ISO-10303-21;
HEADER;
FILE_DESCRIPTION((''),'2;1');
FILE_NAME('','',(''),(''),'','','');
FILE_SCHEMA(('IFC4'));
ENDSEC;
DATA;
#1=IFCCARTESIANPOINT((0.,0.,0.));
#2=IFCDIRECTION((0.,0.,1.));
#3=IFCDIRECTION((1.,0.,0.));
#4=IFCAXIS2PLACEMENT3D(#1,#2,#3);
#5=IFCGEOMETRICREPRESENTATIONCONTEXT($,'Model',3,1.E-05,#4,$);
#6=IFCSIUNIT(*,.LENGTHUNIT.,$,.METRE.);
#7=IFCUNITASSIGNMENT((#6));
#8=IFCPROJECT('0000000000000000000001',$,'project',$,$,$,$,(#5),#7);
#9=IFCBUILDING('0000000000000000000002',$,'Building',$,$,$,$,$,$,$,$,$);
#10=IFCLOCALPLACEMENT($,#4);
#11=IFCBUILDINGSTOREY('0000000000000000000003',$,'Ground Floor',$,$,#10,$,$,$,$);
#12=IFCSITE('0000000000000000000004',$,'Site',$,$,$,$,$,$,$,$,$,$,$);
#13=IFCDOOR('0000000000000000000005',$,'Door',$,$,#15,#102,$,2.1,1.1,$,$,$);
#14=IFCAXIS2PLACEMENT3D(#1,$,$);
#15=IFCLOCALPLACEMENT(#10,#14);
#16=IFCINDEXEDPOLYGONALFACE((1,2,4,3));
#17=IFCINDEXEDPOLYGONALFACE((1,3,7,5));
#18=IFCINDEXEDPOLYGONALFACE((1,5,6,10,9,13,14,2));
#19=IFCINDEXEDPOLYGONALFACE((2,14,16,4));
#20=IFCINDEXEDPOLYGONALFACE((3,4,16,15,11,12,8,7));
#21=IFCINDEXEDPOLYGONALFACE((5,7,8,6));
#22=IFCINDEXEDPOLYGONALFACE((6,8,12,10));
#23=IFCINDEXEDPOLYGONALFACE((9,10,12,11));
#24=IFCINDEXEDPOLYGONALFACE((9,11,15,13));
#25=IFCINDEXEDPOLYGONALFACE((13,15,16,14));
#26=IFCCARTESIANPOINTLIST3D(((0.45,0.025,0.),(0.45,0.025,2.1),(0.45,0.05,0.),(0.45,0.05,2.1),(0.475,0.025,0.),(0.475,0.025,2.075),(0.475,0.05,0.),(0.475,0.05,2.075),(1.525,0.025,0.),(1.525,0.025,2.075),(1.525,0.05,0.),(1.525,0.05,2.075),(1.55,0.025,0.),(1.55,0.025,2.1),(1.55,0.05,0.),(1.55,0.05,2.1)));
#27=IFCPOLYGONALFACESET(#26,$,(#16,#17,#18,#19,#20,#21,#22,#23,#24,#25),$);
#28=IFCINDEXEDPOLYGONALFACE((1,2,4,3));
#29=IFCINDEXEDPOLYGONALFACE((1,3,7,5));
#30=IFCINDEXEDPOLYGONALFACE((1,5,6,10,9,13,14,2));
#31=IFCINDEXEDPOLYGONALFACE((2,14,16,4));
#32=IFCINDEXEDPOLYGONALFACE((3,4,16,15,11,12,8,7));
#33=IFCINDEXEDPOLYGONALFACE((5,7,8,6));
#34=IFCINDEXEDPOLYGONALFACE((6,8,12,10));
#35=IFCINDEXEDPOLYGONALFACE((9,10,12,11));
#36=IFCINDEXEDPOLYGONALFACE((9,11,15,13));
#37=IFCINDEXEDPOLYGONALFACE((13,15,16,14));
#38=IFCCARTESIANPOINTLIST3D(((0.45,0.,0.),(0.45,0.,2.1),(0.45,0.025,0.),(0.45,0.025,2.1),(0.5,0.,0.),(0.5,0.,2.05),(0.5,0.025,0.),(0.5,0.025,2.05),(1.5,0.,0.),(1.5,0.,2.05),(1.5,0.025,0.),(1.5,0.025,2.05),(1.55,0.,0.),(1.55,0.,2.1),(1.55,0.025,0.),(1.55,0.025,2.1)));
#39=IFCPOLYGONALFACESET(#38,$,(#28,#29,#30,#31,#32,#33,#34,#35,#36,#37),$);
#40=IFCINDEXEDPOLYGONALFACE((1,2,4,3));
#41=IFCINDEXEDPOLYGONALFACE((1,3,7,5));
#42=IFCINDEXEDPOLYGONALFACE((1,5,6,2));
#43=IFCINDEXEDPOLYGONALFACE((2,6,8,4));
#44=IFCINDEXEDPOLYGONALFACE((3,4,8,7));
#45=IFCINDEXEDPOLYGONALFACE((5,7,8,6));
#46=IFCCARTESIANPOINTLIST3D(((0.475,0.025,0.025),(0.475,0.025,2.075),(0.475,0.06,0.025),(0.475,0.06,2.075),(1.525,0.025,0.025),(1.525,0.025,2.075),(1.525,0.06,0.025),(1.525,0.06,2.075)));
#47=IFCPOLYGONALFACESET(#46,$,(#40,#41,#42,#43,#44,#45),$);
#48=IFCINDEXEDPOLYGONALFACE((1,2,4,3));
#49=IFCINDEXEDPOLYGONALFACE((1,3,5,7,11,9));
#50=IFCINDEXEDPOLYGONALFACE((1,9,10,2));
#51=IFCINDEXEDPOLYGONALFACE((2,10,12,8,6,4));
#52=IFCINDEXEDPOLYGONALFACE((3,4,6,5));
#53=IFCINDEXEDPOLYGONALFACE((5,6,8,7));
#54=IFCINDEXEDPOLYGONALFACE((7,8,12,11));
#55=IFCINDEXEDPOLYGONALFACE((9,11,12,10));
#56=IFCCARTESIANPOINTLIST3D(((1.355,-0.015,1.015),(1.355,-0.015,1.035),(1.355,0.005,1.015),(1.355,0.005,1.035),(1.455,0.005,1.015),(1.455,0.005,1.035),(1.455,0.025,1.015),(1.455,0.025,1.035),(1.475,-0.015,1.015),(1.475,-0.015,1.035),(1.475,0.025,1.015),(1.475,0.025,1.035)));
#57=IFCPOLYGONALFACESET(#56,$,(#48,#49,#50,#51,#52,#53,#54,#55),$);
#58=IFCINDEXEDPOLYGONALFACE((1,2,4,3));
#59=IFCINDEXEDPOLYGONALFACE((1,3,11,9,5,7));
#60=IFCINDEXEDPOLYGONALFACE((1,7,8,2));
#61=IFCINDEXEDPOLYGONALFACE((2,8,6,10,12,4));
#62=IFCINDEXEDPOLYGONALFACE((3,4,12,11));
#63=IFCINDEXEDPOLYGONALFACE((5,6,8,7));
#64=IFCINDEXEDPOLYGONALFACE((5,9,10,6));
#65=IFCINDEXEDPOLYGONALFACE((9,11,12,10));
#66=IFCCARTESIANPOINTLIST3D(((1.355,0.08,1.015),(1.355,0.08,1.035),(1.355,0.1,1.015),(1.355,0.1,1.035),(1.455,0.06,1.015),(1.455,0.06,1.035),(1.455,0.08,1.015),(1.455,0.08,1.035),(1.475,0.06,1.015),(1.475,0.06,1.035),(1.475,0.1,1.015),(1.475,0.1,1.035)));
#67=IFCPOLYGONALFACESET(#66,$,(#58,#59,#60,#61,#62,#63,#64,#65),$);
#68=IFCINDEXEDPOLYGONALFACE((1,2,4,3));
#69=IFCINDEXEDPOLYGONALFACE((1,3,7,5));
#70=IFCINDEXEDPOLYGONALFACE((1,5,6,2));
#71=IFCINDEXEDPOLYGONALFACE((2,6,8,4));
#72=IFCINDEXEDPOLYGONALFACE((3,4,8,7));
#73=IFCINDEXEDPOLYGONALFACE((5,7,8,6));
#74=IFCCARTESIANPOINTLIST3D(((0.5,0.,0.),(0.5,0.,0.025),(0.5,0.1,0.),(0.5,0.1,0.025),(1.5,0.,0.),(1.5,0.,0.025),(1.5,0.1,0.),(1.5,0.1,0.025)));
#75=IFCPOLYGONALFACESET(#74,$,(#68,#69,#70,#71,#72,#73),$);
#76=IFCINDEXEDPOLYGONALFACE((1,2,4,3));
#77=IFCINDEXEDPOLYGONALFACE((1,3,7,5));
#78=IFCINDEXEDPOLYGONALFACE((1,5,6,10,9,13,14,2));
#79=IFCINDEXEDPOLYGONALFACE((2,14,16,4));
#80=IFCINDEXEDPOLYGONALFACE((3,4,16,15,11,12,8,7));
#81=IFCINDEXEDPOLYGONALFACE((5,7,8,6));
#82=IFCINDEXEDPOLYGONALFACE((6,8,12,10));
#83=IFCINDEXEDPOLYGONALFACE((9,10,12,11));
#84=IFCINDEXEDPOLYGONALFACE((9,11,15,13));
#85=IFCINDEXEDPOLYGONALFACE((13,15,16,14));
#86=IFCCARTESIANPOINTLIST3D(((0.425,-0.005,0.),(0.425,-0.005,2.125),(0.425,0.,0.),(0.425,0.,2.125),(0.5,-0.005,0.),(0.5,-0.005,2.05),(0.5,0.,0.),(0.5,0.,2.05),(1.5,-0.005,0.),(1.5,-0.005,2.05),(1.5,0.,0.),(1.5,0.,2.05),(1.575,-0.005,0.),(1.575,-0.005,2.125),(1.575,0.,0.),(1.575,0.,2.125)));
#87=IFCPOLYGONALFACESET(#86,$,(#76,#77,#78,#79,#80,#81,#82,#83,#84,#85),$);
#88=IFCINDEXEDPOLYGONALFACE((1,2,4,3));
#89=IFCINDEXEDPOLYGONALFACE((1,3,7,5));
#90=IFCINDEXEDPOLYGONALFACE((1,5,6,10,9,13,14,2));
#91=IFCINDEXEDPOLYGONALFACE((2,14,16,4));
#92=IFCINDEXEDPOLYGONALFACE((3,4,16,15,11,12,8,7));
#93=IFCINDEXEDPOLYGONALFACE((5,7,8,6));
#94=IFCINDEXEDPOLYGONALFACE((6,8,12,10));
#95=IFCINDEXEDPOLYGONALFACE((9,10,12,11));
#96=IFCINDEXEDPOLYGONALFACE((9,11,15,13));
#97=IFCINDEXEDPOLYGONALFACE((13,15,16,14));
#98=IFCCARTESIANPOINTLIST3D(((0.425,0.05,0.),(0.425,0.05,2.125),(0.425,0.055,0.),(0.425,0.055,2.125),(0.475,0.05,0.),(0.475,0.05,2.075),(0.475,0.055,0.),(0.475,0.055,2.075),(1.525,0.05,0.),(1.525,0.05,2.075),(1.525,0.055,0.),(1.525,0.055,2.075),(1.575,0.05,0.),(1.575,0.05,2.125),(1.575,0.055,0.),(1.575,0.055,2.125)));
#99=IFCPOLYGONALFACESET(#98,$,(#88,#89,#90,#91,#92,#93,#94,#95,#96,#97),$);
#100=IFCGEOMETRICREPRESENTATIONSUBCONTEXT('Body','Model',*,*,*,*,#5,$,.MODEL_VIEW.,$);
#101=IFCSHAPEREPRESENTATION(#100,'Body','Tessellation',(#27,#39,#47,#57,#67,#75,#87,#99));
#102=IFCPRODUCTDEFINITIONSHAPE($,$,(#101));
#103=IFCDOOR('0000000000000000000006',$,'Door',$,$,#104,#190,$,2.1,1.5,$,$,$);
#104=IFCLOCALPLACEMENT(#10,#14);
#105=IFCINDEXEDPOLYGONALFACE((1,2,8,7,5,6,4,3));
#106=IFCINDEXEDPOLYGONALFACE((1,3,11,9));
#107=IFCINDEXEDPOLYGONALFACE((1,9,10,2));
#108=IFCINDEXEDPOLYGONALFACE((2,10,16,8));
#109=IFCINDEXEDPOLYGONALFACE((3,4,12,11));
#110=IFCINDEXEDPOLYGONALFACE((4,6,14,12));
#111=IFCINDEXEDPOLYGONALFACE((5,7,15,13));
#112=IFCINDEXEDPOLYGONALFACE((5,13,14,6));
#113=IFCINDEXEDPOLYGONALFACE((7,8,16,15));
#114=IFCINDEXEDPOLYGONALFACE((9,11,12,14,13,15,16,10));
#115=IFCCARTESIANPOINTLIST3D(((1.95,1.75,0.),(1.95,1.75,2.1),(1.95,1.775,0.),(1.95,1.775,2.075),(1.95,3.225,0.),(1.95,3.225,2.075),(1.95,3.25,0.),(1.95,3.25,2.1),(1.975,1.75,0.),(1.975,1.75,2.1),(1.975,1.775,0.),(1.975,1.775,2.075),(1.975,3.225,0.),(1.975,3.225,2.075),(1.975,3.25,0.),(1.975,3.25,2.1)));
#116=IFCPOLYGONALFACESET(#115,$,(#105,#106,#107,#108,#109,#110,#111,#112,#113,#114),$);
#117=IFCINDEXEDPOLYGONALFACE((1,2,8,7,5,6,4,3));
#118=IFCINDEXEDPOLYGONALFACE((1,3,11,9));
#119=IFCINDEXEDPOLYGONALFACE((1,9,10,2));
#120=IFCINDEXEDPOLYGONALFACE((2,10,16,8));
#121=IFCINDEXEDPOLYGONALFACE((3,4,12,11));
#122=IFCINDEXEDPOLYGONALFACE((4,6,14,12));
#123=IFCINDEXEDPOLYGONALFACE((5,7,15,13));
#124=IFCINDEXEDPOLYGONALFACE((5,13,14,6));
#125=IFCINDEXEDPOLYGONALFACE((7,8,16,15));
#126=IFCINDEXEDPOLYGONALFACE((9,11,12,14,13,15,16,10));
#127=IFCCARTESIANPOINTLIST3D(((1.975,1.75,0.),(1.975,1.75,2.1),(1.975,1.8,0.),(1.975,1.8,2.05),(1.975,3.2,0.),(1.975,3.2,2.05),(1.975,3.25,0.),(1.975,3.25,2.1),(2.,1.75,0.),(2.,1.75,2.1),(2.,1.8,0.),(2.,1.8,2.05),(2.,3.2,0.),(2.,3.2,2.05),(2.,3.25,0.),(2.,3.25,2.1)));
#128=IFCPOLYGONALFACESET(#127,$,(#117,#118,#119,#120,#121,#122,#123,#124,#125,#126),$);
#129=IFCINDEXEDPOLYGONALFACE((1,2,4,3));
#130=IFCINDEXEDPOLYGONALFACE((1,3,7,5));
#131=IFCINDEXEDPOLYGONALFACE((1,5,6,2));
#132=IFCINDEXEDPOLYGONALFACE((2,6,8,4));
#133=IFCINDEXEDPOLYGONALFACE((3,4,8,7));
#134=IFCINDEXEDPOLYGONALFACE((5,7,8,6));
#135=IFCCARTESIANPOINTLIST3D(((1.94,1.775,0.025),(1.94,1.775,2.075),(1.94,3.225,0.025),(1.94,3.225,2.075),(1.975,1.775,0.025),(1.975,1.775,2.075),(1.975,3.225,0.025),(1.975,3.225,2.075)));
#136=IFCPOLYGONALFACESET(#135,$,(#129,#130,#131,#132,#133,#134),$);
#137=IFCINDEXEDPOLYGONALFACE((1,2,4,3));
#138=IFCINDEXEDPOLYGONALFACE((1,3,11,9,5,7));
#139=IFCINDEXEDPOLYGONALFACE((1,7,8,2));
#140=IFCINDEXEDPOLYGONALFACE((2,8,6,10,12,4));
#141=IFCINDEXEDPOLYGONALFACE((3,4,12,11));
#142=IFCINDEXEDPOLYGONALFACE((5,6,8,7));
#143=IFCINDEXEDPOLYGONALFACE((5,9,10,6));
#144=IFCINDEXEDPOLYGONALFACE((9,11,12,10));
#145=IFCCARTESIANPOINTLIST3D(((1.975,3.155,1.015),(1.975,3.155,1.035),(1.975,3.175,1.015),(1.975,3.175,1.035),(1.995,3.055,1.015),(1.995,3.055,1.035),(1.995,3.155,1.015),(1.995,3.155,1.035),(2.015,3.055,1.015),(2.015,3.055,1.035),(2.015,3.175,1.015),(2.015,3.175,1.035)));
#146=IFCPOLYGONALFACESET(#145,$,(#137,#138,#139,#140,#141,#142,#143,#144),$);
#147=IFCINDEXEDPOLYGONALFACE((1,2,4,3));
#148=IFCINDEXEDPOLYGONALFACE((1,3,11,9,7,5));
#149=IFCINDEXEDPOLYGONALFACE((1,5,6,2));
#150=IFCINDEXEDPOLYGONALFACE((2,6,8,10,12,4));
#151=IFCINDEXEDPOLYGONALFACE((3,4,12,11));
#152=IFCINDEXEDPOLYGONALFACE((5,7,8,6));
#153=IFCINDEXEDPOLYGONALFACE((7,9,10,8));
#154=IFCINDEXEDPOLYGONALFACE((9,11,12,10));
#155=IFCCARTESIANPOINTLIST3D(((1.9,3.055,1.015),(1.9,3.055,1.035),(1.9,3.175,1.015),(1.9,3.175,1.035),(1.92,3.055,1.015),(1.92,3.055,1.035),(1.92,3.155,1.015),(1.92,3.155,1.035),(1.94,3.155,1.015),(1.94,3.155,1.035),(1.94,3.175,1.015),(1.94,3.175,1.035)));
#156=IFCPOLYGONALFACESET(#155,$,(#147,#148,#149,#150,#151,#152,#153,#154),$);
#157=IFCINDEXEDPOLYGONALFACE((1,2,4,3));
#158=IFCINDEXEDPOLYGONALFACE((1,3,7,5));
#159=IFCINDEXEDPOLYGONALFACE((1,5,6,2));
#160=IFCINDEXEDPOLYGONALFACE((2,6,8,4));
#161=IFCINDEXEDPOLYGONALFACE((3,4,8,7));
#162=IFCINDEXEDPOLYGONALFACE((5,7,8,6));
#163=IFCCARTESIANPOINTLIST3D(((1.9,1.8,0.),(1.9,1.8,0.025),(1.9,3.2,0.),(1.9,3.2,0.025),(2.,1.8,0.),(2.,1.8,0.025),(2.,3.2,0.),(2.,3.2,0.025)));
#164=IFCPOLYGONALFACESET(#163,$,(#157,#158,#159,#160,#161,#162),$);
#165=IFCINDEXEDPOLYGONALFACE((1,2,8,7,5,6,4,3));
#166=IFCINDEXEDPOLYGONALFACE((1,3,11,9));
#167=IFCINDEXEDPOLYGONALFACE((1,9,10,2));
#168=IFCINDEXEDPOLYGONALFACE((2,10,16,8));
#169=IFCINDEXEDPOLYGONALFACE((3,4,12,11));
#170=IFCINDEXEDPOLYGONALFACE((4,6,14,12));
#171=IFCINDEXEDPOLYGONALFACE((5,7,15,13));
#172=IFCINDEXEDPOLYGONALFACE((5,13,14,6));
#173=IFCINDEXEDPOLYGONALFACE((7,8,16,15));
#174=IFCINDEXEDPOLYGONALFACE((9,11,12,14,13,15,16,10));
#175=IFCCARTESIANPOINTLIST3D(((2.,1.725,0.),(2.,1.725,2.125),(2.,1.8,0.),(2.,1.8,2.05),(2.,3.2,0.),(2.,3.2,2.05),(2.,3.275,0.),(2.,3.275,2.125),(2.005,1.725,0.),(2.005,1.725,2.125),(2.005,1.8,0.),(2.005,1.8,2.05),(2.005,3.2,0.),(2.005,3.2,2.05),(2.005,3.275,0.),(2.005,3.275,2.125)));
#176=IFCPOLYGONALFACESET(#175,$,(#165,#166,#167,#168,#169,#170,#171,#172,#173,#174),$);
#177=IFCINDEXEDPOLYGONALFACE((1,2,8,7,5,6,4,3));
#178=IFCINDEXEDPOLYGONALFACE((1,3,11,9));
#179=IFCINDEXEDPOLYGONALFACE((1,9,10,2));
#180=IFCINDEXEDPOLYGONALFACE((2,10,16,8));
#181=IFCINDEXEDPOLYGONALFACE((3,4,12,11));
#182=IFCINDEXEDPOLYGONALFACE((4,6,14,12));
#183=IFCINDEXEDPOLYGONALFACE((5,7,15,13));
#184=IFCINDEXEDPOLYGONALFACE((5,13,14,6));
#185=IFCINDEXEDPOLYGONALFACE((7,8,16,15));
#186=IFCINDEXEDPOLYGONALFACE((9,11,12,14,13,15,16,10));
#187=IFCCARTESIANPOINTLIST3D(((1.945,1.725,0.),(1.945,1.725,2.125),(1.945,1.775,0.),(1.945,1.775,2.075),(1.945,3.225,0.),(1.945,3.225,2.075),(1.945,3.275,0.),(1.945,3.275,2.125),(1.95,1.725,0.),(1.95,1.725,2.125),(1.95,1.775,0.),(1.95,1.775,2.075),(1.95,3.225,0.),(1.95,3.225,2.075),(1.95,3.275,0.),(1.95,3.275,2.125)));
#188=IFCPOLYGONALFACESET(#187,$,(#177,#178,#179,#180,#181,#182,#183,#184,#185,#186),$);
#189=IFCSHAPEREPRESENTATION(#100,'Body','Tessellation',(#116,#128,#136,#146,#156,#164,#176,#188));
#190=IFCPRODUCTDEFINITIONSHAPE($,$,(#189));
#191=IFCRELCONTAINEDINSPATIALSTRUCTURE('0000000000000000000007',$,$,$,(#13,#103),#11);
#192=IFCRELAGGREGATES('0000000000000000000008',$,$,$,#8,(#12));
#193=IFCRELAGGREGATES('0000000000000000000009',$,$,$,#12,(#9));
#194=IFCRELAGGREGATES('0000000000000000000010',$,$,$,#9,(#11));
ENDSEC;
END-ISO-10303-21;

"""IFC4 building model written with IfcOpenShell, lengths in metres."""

from ifc_helpers import new_model, si_unit, frame, origin_with_axes, place, context, subcontext, project, spatial, line, indexed_curve, outline, extrude, element, save


model = new_model("IFC4")

# Units and contexts
model_context = context("Model", 3, precision=1e-05, world=origin_with_axes())
body_context = subcontext(model_context, "Body", "Model", "MODEL_VIEW")
ifc_project = project(units=[si_unit("LENGTHUNIT", "METRE")], contexts=[model_context])

# Site, building, storey
site = spatial("IfcSite", under=ifc_project, Name="Site")
building = spatial("IfcBuilding", under=site, Name="Building")
storey_placement = place(None, origin_with_axes())
storey = spatial("IfcBuildingStorey", under=building, at=storey_placement, Name="Ground Floor")

# Doors
door_1_placement = place(storey_placement, frame((0.45, 0.0, 0.0), z_axis=(0.0, 0.0, 1.0), x_axis=(1.0, 0.0, 0.0)))
element("IfcDoor", 1, at=door_1_placement, inside=storey, Name="Door", OverallHeight=2.1, OverallWidth=1.1, context=body_context, shape_type="SweptSolid", body=[
    extrude(outline(indexed_curve([(0.0, 0.0), (0.0, 2.1), (1.1, 2.1), (1.1, 0.0), (1.075, 0.0), (1.075, 2.075), (0.025, 2.075), (0.025, 0.0)], segments=[line(1, 2, 3, 4, 5, 6, 7, 8, 1)])), frame((0.0, 0.025, 0.0), z_axis=(0.0, -1.0, 0.0), x_axis=(1.0, 0.0, 0.0)), (0.0, 0.0, -1.0), 0.025),
    extrude(outline(indexed_curve([(0.0, 0.0), (0.0, 2.1), (1.1, 2.1), (1.1, 0.0), (1.05, 0.0), (1.05, 2.05), (0.05, 2.05), (0.05, 0.0)], segments=[line(1, 2, 3, 4, 5, 6, 7, 8, 1)])), frame((0.0, 0.0, 0.0), z_axis=(0.0, -1.0, 0.0), x_axis=(1.0, 0.0, 0.0)), (0.0, 0.0, -1.0), 0.025),
    extrude(outline(indexed_curve([(0.0, 0.0), (1.05, 0.0), (1.05, 0.035), (0.0, 0.035)], segments=[line(1, 2, 3, 4, 1)])), frame((0.025, 0.025, 0.025), z_axis=(0.0, 0.0, 1.0), x_axis=(1.0, 0.0, 0.0)), (0.0, 0.0, 1.0), 2.05),
    extrude(outline(indexed_curve([(0.0, 0.0), (0.0, -0.04), (-0.12, -0.04), (-0.12, -0.02), (-0.02, -0.02), (-0.02, 0.0)], segments=[line(1, 2, 3, 4, 5, 6, 1)])), frame((1.025, 0.025, 1.015), z_axis=(0.0, 0.0, 1.0), x_axis=(1.0, 0.0, 0.0)), (0.0, 0.0, 1.0), 0.02),
    extrude(outline(indexed_curve([(0.0, 0.0), (0.0, 0.04), (-0.12, 0.04), (-0.12, 0.02), (-0.02, 0.02), (-0.02, 0.0)], segments=[line(1, 2, 3, 4, 5, 6, 1)])), frame((1.025, 0.06, 1.015), z_axis=(0.0, 0.0, 1.0), x_axis=(1.0, 0.0, 0.0)), (0.0, 0.0, 1.0), 0.02),
    extrude(outline(indexed_curve([(0.0, 0.0), (1.0, 0.0), (1.0, 0.1), (0.0, 0.1)], segments=[line(1, 2, 3, 4, 1)])), frame((0.05, 0.0, 0.0), z_axis=(0.0, 0.0, 1.0), x_axis=(1.0, 0.0, 0.0)), (0.0, 0.0, 1.0), 0.025),
    extrude(outline(indexed_curve([(0.0, 0.0), (0.0, 2.125), (1.15, 2.125), (1.15, 0.0), (1.075, 0.0), (1.075, 2.05), (0.075, 2.05), (0.075, 0.0)], segments=[line(1, 2, 3, 4, 5, 6, 7, 8, 1)])), frame((-0.025, -0.005, 0.0), z_axis=(0.0, -1.0, 0.0), x_axis=(1.0, 0.0, 0.0)), (0.0, 0.0, -1.0), 0.005),
    extrude(outline(indexed_curve([(0.0, 0.0), (0.0, 2.125), (1.15, 2.125), (1.15, 0.0), (1.1, 0.0), (1.1, 2.075), (0.05, 2.075), (0.05, 0.0)], segments=[line(1, 2, 3, 4, 5, 6, 7, 8, 1)])), frame((-0.025, 0.05, 0.0), z_axis=(0.0, -1.0, 0.0), x_axis=(1.0, 0.0, 0.0)), (0.0, 0.0, -1.0), 0.005),
])
door_2_placement = place(storey_placement, frame((2.0, 1.75, 0.0), z_axis=(0.0, 0.0, 1.0), x_axis=(0.0, 1.0, 0.0)))
element("IfcDoor", 2, at=door_2_placement, inside=storey, Name="Door", OverallHeight=2.1, OverallWidth=1.5, context=body_context, shape_type="SweptSolid", body=[
    extrude(outline(indexed_curve([(0.0, 0.0), (0.0, 2.1), (1.5, 2.1), (1.5, 0.0), (1.475, 0.0), (1.475, 2.075), (0.025, 2.075), (0.025, 0.0)], segments=[line(1, 2, 3, 4, 5, 6, 7, 8, 1)])), frame((0.0, 0.025, 0.0), z_axis=(0.0, -1.0, 0.0), x_axis=(1.0, 0.0, 0.0)), (0.0, 0.0, -1.0), 0.025),
    extrude(outline(indexed_curve([(0.0, 0.0), (0.0, 2.1), (1.5, 2.1), (1.5, 0.0), (1.45, 0.0), (1.45, 2.05), (0.05, 2.05), (0.05, 0.0)], segments=[line(1, 2, 3, 4, 5, 6, 7, 8, 1)])), frame((0.0, 0.0, 0.0), z_axis=(0.0, -1.0, 0.0), x_axis=(1.0, 0.0, 0.0)), (0.0, 0.0, -1.0), 0.025),
    extrude(outline(indexed_curve([(0.0, 0.0), (1.45, 0.0), (1.45, 0.035), (0.0, 0.035)], segments=[line(1, 2, 3, 4, 1)])), frame((0.025, 0.025, 0.025), z_axis=(0.0, 0.0, 1.0), x_axis=(1.0, 0.0, 0.0)), (0.0, 0.0, 1.0), 2.05),
    extrude(outline(indexed_curve([(0.0, 0.0), (0.0, -0.04), (-0.12, -0.04), (-0.12, -0.02), (-0.02, -0.02), (-0.02, 0.0)], segments=[line(1, 2, 3, 4, 5, 6, 1)])), frame((1.425, 0.025, 1.015), z_axis=(0.0, 0.0, 1.0), x_axis=(1.0, 0.0, 0.0)), (0.0, 0.0, 1.0), 0.02),
    extrude(outline(indexed_curve([(0.0, 0.0), (0.0, 0.04), (-0.12, 0.04), (-0.12, 0.02), (-0.02, 0.02), (-0.02, 0.0)], segments=[line(1, 2, 3, 4, 5, 6, 1)])), frame((1.425, 0.06, 1.015), z_axis=(0.0, 0.0, 1.0), x_axis=(1.0, 0.0, 0.0)), (0.0, 0.0, 1.0), 0.02),
    extrude(outline(indexed_curve([(0.0, 0.0), (1.4, 0.0), (1.4, 0.1), (0.0, 0.1)], segments=[line(1, 2, 3, 4, 1)])), frame((0.05, 0.0, 0.0), z_axis=(0.0, 0.0, 1.0), x_axis=(1.0, 0.0, 0.0)), (0.0, 0.0, 1.0), 0.025),
    extrude(outline(indexed_curve([(0.0, 0.0), (0.0, 2.125), (1.55, 2.125), (1.55, 0.0), (1.475, 0.0), (1.475, 2.05), (0.075, 2.05), (0.075, 0.0)], segments=[line(1, 2, 3, 4, 5, 6, 7, 8, 1)])), frame((-0.025, -0.005, 0.0), z_axis=(0.0, -1.0, 0.0), x_axis=(1.0, 0.0, 0.0)), (0.0, 0.0, -1.0), 0.005),
    extrude(outline(indexed_curve([(0.0, 0.0), (0.0, 2.125), (1.55, 2.125), (1.55, 0.0), (1.5, 0.0), (1.5, 2.075), (0.05, 2.075), (0.05, 0.0)], segments=[line(1, 2, 3, 4, 5, 6, 7, 8, 1)])), frame((-0.025, 0.05, 0.0), z_axis=(0.0, -1.0, 0.0), x_axis=(1.0, 0.0, 0.0)), (0.0, 0.0, -1.0), 0.005),
])

save(model, "model.ifc")
